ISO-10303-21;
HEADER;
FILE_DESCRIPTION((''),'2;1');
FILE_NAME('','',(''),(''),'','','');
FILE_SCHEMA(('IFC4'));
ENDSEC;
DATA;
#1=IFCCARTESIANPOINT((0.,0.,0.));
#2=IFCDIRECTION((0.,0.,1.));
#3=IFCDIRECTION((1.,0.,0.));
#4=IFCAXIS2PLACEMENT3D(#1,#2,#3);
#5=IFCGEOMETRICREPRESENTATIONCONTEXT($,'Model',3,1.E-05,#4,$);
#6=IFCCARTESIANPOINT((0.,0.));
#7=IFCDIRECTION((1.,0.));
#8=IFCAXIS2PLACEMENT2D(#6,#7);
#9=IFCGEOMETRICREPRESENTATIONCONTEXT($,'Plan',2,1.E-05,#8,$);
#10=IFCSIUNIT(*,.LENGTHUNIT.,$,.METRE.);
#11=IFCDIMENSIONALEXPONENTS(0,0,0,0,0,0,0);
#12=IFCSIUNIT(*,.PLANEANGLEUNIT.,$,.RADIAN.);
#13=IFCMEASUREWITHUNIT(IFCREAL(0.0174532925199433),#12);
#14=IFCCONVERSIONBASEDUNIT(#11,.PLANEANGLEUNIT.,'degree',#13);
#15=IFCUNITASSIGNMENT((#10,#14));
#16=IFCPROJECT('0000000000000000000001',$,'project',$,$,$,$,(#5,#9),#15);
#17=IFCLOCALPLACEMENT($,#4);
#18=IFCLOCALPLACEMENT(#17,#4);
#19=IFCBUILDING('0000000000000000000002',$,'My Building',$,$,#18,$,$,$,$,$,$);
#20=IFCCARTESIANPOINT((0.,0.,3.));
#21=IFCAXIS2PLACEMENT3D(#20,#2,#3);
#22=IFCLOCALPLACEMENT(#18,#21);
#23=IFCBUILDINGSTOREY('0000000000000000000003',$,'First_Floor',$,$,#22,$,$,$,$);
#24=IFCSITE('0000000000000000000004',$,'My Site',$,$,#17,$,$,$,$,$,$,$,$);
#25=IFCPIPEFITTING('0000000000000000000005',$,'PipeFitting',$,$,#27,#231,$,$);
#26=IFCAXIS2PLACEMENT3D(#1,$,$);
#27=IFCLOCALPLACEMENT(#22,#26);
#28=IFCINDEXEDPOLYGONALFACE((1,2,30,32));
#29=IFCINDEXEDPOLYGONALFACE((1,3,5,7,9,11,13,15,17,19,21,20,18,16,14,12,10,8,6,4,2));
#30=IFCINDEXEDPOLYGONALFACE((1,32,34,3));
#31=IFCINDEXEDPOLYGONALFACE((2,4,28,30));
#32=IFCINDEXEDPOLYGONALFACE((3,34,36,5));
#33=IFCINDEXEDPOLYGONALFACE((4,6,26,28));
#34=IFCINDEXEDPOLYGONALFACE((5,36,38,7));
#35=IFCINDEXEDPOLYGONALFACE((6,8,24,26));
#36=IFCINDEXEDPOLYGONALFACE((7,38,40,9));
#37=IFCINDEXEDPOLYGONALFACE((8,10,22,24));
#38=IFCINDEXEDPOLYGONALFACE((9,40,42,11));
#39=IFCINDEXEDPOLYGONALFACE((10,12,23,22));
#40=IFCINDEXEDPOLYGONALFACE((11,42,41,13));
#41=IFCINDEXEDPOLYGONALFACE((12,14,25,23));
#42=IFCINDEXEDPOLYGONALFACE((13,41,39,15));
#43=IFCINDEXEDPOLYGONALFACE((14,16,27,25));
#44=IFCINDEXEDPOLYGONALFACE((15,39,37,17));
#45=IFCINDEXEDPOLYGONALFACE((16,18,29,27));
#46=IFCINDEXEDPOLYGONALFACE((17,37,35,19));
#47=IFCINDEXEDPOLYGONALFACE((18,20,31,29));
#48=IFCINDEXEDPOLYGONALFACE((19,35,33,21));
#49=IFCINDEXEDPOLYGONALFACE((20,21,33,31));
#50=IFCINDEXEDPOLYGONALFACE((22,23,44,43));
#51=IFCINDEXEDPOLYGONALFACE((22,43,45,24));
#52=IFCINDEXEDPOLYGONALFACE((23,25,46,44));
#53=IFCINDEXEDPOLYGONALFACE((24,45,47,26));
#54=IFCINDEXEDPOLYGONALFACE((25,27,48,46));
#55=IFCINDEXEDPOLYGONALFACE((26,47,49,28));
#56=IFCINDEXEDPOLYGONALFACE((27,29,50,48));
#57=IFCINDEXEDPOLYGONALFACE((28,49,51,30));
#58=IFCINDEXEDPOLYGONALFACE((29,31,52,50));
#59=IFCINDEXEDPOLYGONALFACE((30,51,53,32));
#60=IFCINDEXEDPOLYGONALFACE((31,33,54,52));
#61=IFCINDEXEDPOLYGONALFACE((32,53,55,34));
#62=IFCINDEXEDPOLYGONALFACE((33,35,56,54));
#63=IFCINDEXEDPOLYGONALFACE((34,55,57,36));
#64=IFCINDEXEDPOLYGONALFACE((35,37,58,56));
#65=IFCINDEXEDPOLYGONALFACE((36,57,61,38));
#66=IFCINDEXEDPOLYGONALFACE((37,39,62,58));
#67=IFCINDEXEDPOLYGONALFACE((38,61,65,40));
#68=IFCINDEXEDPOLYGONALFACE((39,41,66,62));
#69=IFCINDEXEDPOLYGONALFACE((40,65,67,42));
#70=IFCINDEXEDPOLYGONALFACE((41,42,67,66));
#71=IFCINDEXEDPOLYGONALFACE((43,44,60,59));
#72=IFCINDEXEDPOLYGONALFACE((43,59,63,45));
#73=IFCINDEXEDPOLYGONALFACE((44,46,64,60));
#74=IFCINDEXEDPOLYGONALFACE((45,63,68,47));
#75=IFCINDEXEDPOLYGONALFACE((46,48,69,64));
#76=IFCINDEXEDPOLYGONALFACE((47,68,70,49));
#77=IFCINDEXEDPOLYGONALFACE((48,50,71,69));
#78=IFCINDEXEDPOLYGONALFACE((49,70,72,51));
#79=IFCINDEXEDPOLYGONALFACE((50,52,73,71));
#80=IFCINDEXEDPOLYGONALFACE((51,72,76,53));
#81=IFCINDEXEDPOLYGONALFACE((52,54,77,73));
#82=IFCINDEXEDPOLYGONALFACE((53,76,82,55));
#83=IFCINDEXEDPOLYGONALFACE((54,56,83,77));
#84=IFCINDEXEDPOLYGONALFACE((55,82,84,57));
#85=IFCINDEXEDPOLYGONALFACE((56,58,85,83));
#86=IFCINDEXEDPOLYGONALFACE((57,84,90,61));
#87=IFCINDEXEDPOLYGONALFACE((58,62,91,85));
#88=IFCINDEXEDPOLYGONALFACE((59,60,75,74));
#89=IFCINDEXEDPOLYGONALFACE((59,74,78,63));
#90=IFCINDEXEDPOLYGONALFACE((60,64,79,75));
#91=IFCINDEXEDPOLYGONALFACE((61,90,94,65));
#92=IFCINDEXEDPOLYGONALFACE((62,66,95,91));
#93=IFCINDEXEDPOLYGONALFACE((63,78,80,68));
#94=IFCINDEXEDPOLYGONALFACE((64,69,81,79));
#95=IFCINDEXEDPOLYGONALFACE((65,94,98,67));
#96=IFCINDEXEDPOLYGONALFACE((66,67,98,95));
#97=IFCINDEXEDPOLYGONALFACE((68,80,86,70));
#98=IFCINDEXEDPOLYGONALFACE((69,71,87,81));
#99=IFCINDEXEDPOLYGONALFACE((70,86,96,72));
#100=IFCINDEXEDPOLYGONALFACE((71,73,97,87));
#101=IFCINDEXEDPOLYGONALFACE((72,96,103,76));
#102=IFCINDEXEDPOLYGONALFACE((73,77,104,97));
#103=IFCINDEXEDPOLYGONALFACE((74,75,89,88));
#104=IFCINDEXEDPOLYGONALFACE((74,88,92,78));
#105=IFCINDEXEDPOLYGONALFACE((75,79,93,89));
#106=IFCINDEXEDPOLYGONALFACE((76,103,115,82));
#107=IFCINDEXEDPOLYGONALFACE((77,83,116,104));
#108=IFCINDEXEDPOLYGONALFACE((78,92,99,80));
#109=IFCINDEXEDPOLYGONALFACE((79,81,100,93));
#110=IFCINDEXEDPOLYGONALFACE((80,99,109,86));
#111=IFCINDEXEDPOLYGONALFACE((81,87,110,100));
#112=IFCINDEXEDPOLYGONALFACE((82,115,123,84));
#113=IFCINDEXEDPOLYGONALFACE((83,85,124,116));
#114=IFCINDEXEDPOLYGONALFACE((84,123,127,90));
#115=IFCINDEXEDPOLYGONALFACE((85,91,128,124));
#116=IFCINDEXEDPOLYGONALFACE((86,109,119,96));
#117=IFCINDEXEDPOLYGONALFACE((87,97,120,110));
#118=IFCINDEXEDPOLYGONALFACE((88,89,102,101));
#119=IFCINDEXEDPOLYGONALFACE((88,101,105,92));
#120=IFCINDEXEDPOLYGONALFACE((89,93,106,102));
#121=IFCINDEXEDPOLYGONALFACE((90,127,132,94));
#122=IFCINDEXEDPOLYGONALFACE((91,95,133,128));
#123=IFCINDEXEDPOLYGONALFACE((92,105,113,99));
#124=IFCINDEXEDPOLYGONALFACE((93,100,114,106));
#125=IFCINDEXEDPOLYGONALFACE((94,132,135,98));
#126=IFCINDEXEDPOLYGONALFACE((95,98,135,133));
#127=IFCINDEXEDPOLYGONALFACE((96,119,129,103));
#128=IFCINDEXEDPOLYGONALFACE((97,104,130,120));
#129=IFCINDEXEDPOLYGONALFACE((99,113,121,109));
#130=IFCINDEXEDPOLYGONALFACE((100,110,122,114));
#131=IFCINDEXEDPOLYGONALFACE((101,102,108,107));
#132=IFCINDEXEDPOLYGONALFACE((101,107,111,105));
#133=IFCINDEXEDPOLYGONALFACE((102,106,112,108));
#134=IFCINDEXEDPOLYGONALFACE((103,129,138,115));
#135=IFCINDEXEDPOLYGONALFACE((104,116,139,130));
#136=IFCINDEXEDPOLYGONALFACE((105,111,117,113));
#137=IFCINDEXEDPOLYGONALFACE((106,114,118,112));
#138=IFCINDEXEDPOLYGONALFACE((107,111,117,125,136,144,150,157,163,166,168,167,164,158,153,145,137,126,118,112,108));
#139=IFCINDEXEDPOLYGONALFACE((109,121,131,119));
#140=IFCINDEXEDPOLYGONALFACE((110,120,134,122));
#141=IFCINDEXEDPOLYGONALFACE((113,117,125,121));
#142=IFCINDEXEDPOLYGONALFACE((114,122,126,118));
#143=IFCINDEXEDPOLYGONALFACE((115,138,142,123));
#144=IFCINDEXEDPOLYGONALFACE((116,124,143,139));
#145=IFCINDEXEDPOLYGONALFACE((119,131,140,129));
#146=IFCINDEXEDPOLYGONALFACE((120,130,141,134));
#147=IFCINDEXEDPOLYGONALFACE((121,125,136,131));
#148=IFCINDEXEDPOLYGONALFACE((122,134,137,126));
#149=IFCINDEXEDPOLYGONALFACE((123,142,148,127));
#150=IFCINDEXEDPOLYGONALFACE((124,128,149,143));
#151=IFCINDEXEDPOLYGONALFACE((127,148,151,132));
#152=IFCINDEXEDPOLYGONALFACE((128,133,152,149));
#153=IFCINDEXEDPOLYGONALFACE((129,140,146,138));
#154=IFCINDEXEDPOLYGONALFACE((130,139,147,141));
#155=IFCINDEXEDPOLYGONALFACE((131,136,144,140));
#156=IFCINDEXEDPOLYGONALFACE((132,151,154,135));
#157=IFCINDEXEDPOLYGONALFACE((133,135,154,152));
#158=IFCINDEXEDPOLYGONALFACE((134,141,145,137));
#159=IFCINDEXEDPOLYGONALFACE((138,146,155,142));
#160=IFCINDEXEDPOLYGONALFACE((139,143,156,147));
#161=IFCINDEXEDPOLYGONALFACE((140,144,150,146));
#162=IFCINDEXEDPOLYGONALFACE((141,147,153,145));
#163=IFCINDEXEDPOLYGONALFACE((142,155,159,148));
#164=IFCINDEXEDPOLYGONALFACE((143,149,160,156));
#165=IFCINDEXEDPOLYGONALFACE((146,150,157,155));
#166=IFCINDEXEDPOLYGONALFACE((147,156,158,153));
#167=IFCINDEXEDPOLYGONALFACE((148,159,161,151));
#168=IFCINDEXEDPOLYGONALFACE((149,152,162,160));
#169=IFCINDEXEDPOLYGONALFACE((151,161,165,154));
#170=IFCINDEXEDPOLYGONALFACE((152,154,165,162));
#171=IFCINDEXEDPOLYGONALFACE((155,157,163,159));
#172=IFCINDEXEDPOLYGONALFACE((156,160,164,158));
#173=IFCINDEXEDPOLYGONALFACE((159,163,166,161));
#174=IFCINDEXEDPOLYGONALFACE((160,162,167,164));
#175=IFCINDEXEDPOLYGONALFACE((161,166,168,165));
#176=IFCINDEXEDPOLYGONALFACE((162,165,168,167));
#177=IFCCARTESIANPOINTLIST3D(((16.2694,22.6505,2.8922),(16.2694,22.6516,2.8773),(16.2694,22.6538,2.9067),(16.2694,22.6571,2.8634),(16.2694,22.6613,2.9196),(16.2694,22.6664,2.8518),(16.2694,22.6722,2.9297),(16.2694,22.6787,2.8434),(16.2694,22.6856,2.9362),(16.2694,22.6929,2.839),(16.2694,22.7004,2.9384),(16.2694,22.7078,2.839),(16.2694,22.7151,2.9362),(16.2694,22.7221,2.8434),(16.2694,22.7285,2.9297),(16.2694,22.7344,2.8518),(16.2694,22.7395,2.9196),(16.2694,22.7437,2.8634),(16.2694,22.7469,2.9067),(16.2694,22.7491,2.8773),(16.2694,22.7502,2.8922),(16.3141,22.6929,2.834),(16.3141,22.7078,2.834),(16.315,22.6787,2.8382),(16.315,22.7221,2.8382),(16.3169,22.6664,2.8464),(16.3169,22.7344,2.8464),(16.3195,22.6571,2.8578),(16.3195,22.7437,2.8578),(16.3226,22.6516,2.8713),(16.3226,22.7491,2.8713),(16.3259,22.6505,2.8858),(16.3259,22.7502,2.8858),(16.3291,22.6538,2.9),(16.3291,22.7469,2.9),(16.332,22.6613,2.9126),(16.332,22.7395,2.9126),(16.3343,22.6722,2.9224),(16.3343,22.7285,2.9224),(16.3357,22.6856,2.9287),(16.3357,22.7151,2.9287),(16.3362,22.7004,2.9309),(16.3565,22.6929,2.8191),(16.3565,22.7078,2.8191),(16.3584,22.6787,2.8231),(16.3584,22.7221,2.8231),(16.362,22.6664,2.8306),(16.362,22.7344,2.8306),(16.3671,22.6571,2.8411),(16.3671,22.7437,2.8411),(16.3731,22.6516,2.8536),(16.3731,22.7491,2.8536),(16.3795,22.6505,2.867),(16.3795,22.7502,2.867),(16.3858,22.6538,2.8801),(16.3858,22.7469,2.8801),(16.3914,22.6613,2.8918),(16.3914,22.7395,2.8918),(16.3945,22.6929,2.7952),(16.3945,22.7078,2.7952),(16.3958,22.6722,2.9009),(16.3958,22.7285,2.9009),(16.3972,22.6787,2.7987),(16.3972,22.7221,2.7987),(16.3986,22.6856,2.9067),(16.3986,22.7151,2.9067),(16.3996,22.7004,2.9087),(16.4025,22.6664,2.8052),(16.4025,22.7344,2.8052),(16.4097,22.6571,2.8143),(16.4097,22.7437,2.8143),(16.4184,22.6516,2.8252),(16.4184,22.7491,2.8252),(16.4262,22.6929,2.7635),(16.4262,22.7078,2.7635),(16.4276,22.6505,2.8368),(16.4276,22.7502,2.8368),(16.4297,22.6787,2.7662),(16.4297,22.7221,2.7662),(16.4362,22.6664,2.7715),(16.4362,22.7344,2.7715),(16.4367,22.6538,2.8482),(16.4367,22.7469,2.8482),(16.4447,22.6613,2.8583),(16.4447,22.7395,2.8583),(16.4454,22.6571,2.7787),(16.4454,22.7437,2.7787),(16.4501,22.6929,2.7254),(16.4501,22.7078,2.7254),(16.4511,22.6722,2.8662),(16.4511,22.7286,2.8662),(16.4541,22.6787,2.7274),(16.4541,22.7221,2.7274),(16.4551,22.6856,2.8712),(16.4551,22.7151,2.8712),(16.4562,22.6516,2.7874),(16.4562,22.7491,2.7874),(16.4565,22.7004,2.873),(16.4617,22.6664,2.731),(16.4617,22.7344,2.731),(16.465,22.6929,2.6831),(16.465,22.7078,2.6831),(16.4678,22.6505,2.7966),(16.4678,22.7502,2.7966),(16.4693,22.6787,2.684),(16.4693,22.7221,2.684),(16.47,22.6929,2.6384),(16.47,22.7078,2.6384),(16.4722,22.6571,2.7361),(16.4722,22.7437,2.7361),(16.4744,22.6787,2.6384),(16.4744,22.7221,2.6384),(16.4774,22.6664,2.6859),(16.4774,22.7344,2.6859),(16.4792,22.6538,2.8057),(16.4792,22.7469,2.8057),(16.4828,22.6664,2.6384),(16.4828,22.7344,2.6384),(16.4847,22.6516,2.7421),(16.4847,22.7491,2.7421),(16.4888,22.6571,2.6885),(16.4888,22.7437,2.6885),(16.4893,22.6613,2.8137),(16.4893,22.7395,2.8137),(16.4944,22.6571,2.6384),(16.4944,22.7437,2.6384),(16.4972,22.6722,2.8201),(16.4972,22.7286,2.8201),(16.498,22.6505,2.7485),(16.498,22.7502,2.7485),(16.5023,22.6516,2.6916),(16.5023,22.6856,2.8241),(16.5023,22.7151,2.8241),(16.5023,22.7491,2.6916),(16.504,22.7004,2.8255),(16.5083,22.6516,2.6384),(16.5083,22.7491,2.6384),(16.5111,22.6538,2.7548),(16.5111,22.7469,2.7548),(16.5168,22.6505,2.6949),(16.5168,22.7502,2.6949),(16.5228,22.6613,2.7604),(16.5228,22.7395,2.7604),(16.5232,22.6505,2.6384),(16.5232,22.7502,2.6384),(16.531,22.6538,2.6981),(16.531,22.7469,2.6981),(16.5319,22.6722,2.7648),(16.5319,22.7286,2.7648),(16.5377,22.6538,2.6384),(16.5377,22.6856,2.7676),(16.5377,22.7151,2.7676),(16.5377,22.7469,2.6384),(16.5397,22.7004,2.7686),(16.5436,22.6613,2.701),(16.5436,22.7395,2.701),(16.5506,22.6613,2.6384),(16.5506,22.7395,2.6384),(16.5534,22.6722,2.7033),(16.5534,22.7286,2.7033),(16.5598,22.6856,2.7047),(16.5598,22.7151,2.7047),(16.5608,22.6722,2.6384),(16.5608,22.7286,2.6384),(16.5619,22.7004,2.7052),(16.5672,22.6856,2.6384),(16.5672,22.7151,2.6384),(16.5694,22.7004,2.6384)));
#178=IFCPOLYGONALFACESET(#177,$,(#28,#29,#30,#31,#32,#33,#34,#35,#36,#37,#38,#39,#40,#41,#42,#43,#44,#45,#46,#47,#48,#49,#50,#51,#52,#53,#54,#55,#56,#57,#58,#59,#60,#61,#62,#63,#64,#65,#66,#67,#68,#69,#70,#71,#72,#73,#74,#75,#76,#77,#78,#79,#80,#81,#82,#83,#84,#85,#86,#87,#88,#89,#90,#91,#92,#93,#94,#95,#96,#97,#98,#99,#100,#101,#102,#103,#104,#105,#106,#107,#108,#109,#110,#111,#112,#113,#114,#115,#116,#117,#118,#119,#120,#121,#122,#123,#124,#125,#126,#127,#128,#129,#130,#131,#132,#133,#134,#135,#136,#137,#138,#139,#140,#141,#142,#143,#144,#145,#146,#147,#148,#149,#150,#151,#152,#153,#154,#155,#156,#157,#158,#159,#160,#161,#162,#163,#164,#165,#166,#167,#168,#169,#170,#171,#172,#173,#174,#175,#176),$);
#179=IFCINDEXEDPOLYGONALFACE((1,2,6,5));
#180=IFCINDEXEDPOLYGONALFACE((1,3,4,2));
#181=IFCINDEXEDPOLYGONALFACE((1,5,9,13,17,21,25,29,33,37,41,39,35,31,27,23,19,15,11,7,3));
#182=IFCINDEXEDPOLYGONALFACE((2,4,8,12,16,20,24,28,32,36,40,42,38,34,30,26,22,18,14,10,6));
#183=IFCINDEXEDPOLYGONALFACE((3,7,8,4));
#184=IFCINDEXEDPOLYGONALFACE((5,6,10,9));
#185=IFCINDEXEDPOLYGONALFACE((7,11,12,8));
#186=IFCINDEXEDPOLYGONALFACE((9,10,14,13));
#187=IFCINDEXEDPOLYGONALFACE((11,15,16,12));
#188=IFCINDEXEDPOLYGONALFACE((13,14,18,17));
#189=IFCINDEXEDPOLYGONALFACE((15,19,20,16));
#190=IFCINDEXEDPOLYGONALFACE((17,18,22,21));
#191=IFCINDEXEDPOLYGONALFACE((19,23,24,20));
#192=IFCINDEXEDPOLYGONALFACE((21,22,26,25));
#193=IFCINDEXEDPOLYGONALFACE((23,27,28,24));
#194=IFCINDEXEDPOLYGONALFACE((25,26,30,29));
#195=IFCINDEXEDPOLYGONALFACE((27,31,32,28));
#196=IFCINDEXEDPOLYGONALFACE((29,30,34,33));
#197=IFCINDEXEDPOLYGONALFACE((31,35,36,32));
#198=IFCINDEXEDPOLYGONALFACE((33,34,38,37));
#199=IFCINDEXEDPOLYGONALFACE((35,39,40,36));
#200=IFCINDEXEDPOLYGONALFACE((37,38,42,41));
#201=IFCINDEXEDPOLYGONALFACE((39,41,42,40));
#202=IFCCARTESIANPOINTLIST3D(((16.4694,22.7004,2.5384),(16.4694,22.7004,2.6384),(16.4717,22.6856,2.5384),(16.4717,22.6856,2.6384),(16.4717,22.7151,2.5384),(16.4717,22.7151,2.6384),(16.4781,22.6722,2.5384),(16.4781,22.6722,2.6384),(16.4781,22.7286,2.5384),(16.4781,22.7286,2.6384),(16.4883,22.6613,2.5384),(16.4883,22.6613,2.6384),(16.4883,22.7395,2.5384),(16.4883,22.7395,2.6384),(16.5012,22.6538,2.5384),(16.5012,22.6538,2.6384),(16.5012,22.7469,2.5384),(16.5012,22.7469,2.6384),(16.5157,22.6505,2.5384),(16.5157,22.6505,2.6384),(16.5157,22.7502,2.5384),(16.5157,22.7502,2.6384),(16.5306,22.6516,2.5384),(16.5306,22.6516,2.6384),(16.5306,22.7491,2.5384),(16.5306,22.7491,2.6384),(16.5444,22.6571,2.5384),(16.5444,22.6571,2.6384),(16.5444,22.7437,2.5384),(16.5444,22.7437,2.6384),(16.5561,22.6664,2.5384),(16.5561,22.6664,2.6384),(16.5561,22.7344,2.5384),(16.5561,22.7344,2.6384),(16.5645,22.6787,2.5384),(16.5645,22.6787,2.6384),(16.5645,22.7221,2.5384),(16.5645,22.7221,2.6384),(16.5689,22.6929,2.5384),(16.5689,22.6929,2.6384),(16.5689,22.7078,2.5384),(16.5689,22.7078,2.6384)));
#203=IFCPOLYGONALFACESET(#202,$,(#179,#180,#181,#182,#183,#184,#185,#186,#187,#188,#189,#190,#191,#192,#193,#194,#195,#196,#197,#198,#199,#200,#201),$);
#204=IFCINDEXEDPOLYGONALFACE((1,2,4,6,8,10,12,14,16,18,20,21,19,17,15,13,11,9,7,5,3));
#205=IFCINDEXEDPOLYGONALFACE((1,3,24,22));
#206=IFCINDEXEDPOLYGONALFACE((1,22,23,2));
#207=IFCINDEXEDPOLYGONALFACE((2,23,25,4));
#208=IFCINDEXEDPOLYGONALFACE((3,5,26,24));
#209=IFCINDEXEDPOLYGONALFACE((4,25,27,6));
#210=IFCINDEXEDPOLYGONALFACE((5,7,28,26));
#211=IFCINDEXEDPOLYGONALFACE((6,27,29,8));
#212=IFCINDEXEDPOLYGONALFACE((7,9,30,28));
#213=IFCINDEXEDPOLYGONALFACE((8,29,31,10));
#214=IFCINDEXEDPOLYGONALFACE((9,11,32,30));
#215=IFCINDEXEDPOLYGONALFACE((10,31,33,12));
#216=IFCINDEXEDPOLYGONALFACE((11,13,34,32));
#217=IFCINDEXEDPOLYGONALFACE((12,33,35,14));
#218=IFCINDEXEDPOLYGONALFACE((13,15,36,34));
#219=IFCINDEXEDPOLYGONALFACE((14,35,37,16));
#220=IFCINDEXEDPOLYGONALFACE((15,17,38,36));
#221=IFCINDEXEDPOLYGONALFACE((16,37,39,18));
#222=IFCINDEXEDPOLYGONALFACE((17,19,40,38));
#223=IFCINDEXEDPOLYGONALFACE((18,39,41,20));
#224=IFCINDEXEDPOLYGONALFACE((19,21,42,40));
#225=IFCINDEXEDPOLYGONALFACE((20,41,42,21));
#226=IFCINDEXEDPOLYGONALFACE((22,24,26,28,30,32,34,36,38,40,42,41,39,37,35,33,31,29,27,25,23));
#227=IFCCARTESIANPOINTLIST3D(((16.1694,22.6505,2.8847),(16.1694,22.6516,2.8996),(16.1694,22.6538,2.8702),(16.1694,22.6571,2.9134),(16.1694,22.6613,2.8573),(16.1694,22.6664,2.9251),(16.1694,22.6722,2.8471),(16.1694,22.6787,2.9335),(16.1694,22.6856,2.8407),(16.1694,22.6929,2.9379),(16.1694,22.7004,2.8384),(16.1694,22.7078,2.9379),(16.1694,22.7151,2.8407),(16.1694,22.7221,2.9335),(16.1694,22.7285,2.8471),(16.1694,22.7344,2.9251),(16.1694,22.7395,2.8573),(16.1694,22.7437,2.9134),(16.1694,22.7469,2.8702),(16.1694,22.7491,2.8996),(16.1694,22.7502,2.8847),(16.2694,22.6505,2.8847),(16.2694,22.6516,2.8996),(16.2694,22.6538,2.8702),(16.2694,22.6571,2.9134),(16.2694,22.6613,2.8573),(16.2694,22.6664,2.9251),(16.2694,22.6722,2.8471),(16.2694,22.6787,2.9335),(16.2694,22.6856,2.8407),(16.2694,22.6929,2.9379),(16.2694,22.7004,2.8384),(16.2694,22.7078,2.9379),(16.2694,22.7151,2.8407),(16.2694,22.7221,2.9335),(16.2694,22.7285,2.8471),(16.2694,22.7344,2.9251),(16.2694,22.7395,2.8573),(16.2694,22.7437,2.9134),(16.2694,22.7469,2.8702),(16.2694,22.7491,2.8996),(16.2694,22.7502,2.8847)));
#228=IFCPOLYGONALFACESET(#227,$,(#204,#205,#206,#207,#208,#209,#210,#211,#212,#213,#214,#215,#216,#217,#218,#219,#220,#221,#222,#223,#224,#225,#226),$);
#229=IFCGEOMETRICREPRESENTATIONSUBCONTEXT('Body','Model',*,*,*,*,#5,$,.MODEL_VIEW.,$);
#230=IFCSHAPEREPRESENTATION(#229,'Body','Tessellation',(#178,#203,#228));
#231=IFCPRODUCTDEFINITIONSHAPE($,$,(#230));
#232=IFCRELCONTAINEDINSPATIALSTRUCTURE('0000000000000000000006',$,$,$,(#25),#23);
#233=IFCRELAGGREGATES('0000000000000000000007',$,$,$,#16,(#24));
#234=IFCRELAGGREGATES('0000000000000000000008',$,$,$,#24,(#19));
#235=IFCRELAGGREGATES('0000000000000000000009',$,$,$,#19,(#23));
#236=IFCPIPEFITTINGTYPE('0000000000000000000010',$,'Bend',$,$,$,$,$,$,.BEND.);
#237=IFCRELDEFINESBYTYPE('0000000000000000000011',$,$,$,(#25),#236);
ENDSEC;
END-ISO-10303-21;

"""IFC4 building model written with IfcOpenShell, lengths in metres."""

from ifc_helpers import new_model, entity, si_unit, converted_unit, frame, origin_with_axes, origin_2d_with_axis, place, context, subcontext, project, spatial, circle, extrude, source, transform, mapped, type_object, type_shapes, element, save


model = new_model("IFC4")

# Units and contexts
model_context = context("Model", 3, precision=1e-05, world=origin_with_axes())
plan_context = context("Plan", 2, precision=1e-05, world=origin_2d_with_axis())
body_context = subcontext(model_context, "Body", "Model", "MODEL_VIEW")
ifc_project = project(units=[si_unit("LENGTHUNIT", "METRE"), converted_unit("PLANEANGLEUNIT", "degree", entity("IfcReal", 0.0174532925199433), si_unit("PLANEANGLEUNIT", "RADIAN"), dimensions=[0, 0, 0, 0, 0, 0, 0])], contexts=[model_context, plan_context])

# Site, building, storey
site_placement = place(None, origin_with_axes())
site = spatial("IfcSite", under=ifc_project, at=site_placement, Name="My Site")
building_placement = place(site_placement, origin_with_axes())
building = spatial("IfcBuilding", under=site, at=building_placement, Name="My Building")
storey_placement = place(building_placement, frame((0.0, 0.0, 3.0), z_axis=(0.0, 0.0, 1.0), x_axis=(1.0, 0.0, 0.0)))
storey = spatial("IfcBuildingStorey", under=building, at=storey_placement, Name="First_Floor")

# Pipe fitting
pipe_fitting_type = type_object("IfcPipeFittingType", Name="Bend", PredefinedType="BEND")
shared_shape = source(origin_with_axes(), body_context, "Body", "SolidModel", [
    entity("IfcSweptDiskSolid", entity("IfcIndexedPolyCurve", entity("IfcCartesianPointList3D", [[0.0, 0.0, -0.1], [0.0732, 0.0, -0.2768], [0.25, 0.0, -0.35]]), [entity("IfcArcIndex", [1, 2, 3])]), 0.05),
    extrude(circle(Radius=0.05), origin_with_axes(), (0.0, 0.0, -1.0), 0.1),
    extrude(circle(Radius=0.05), frame((0.25, 0.0, -0.35), z_axis=(1.0, 0.0, 0.0), x_axis=(0.0, 0.0, 1.0)), (0.0, 0.0, 1.0), 0.1),
])
type_shapes(pipe_fitting_type, [shared_shape])
for number, where, z_axis, x_axis, name in (
    (1, (16.5194, 22.7004, 2.5384), (0.000001, 0.0, -1.0), (-1.0, -0.000001, -0.000001), "PipeFitting"),
):
    element("IfcPipeFitting", number, at=place(storey_placement, frame(where, z_axis=z_axis, x_axis=x_axis)), inside=storey, type_object=pipe_fitting_type, Name=name, context=body_context, shape_type="MappedRepresentation", body=[
        mapped(shared_shape, transform((0.0, 0.0, 0.0), x_axis=(1.0, 0.0, 0.0), y_axis=(0.0, 1.0, 0.0), z_axis=(0.0, 0.0, 1.0), scale=1.0)),
    ])

save(model, "model.ifc")
